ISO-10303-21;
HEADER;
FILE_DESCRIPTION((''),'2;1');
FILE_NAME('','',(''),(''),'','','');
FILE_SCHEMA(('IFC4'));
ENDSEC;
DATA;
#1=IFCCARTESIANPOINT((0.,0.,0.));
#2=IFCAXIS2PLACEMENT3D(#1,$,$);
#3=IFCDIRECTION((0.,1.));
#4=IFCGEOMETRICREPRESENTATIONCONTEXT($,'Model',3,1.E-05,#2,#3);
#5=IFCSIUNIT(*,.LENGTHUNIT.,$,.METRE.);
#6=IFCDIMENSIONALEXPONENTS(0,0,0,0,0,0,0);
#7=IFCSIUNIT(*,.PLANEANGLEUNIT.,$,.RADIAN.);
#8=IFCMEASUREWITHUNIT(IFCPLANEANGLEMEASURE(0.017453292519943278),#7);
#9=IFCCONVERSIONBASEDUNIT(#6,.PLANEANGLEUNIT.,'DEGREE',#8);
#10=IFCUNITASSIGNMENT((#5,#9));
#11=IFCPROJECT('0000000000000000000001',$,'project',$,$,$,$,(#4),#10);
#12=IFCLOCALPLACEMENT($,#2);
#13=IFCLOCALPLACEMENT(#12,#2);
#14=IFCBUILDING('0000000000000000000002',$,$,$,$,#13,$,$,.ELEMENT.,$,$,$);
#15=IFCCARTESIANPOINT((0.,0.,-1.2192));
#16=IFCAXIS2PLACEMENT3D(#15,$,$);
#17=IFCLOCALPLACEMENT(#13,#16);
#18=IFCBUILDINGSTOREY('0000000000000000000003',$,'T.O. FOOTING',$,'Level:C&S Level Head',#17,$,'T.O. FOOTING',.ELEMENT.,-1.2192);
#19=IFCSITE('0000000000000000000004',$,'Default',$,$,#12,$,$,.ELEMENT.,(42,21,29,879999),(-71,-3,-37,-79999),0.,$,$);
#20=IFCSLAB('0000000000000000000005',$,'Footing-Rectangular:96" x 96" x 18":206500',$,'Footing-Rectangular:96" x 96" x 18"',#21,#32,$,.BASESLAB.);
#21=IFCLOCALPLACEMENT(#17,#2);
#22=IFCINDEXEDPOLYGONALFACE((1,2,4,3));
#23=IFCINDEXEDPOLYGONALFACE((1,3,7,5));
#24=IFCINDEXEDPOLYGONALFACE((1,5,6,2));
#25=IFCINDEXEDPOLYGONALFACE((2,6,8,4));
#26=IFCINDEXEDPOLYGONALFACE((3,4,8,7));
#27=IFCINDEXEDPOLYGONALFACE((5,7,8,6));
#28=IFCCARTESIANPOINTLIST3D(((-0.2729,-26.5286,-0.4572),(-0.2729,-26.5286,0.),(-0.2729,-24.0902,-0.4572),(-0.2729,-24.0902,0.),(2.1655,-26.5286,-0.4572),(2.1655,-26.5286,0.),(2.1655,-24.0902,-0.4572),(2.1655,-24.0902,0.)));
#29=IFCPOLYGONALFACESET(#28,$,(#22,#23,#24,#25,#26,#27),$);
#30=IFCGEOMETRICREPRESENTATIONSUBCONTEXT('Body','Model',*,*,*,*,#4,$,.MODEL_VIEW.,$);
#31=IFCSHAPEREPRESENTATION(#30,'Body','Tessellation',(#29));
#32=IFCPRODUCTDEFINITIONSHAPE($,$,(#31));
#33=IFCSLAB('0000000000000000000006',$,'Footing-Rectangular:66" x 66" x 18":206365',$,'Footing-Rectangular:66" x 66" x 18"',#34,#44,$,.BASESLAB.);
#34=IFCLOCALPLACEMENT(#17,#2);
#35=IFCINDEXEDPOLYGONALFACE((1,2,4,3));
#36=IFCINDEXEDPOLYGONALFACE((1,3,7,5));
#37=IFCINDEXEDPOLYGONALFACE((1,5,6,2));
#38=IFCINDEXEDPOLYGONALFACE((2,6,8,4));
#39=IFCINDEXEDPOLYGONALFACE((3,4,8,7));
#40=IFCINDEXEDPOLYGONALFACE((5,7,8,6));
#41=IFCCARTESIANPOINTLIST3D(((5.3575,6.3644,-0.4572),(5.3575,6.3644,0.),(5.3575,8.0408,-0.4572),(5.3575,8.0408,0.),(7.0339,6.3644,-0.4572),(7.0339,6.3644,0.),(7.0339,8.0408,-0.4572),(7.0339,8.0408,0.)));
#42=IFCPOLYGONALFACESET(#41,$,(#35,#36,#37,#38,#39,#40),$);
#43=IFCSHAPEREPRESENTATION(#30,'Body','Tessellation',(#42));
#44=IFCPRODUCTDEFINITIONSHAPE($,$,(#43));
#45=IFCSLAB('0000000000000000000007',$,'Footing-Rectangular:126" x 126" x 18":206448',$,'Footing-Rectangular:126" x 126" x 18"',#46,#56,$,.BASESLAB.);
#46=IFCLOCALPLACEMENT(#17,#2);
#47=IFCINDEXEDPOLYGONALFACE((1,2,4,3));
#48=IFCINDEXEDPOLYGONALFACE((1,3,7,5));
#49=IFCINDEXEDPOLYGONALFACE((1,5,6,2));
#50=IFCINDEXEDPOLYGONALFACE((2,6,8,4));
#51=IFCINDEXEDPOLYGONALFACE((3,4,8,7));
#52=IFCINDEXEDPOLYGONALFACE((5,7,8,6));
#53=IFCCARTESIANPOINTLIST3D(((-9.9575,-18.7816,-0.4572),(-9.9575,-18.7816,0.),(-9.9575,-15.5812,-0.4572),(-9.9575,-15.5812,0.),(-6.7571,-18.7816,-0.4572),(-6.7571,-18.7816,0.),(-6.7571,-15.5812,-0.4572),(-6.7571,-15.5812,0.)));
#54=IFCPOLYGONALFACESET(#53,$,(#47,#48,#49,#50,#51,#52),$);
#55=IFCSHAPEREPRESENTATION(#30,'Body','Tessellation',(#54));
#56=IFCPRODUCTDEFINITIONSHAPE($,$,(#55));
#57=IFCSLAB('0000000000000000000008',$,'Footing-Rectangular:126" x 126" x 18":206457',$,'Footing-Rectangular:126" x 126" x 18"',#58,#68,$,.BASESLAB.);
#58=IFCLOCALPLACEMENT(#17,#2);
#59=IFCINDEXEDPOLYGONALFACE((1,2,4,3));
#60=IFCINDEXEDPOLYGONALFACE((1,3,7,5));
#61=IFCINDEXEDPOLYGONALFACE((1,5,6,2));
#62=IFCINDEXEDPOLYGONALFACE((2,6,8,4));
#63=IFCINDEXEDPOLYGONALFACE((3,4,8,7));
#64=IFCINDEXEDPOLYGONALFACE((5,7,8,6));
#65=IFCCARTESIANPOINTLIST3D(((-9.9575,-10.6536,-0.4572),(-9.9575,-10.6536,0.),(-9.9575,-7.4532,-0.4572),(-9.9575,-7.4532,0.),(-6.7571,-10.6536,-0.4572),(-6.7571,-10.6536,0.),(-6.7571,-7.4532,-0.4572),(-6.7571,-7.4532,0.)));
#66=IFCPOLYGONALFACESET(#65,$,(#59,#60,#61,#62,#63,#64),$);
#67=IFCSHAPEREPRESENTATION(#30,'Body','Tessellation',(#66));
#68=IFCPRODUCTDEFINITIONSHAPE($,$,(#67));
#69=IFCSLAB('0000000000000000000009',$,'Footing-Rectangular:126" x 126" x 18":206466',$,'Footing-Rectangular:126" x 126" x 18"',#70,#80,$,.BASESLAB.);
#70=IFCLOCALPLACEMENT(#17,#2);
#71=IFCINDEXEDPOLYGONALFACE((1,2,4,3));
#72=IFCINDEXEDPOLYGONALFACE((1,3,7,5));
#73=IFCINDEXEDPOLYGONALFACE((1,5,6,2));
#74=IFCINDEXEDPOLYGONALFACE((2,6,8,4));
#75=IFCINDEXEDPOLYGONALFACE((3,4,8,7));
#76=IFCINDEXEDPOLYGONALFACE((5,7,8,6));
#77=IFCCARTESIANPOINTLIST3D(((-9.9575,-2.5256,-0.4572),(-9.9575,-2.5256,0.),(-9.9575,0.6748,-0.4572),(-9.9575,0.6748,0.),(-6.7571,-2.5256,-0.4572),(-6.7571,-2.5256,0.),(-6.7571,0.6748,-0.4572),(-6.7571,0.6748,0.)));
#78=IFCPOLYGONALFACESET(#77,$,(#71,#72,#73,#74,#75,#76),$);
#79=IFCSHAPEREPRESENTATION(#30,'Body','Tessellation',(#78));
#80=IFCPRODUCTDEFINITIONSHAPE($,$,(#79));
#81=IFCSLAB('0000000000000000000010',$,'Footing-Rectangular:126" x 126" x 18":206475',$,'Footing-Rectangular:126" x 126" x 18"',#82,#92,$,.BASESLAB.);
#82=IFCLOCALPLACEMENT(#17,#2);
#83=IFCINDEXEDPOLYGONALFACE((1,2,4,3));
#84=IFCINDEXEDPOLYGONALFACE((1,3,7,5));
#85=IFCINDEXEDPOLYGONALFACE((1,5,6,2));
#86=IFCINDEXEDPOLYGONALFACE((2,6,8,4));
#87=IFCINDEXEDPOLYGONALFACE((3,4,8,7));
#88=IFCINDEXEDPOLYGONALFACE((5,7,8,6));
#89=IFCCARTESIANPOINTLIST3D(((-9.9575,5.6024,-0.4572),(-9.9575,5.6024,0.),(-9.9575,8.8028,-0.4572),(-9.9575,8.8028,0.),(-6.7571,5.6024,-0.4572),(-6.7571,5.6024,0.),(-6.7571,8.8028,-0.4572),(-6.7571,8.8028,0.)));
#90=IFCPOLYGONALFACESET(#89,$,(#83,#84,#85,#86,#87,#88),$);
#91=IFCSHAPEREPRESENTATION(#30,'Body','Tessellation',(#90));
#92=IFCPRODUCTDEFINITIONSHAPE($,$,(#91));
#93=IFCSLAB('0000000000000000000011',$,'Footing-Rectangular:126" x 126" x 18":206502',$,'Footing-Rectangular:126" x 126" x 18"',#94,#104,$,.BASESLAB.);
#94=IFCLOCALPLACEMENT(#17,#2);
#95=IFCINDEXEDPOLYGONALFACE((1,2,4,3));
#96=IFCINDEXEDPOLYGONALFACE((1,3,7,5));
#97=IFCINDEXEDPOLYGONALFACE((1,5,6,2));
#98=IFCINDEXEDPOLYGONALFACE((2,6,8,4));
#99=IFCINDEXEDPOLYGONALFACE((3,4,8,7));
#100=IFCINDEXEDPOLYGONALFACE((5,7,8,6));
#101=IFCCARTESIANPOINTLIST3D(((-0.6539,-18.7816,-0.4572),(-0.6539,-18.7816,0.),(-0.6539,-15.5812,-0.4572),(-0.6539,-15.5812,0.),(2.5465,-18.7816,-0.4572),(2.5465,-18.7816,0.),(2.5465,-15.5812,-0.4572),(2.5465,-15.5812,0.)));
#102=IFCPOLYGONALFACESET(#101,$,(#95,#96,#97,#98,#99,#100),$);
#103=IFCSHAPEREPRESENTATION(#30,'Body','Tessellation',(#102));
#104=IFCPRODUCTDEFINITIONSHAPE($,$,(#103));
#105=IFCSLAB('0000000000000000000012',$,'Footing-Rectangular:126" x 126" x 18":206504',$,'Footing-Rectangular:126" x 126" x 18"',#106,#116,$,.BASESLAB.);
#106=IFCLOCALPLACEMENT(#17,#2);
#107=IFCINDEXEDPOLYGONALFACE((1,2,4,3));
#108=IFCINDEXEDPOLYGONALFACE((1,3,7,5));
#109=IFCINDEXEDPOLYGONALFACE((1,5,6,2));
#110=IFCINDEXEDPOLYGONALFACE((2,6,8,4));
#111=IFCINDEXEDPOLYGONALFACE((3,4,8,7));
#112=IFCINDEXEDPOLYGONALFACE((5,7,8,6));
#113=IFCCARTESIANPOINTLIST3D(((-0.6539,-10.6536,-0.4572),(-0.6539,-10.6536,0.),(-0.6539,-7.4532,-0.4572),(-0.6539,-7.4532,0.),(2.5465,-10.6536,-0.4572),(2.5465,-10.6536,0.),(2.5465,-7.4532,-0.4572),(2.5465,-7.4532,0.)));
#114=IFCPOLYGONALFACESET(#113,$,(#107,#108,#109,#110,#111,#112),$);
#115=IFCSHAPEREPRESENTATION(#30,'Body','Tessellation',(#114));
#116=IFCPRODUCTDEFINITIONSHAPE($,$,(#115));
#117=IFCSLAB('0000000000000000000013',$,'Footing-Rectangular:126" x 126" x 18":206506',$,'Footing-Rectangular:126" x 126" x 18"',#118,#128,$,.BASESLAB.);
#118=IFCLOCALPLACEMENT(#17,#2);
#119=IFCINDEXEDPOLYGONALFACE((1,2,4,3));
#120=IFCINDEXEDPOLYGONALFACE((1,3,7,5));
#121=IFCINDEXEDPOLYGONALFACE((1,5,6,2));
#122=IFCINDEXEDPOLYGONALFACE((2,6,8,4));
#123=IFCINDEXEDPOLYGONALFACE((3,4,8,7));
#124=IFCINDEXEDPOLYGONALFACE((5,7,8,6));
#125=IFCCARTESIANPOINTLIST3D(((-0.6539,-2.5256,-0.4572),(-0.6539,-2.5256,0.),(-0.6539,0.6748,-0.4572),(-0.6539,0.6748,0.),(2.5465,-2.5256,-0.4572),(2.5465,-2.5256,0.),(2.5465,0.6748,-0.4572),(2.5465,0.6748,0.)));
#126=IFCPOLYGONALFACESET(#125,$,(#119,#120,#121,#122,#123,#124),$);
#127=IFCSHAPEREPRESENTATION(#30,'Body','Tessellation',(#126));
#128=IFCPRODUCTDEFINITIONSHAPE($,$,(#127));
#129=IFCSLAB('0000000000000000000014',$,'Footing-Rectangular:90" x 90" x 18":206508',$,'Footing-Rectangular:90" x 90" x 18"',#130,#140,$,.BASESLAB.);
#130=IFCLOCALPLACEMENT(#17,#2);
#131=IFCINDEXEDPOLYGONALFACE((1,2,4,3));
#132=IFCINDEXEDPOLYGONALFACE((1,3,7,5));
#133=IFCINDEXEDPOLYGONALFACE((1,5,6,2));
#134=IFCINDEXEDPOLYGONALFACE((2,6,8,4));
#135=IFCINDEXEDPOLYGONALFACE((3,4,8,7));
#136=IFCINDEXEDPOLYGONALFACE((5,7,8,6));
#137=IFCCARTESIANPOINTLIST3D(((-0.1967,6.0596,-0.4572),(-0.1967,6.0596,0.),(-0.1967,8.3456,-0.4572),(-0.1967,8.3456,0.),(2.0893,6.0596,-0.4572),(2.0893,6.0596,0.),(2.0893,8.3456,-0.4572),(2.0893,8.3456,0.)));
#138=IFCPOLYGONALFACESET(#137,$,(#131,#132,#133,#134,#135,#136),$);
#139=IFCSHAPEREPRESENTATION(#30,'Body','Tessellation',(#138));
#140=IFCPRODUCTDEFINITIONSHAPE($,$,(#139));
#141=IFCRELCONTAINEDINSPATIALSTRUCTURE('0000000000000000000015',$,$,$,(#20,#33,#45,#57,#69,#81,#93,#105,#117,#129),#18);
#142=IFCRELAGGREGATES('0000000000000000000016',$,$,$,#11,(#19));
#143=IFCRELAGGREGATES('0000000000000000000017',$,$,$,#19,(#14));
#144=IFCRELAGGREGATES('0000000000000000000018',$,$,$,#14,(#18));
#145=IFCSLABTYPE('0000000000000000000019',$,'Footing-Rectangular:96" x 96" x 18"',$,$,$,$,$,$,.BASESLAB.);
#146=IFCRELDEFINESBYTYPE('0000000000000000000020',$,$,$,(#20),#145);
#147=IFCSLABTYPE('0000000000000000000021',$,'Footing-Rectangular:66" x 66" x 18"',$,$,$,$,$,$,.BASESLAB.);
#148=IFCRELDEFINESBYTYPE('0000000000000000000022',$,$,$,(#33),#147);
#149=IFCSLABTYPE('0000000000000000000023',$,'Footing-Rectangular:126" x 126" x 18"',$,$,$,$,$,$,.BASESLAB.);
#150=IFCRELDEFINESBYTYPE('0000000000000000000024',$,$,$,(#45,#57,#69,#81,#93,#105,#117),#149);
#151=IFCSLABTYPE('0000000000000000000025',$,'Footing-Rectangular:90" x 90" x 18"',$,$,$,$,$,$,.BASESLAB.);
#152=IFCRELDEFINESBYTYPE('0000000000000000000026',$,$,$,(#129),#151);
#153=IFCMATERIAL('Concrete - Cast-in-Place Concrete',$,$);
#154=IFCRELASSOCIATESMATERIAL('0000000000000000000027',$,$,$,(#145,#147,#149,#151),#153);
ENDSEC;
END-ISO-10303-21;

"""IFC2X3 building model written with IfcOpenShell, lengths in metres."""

from ifc_helpers import new_model, entity, si_unit, converted_unit, direction, frame, frame_2d, origin, origin_2d_with_axis, place, context, subcontext, project, spatial, rectangle, extrude, material, type_object, element, save


model = new_model("IFC2X3")

# Units and contexts
model_context = context("Model", 3, precision=1e-05, world=origin(), true_north=direction((0.0, 1.0)))
body_context = subcontext(model_context, "Body", "Model", "MODEL_VIEW")
ifc_project = project(units=[si_unit("LENGTHUNIT", "METRE"), converted_unit("PLANEANGLEUNIT", "DEGREE", entity("IfcPlaneAngleMeasure", 0.017453292519943278), si_unit("PLANEANGLEUNIT", "RADIAN"), dimensions=[0, 0, 0, 0, 0, 0, 0])], contexts=[model_context])

# Site, building, storey
site_placement = place(None, origin())
site = spatial("IfcSite", under=ifc_project, at=site_placement, Name="Default", CompositionType="ELEMENT", RefLatitude=(42, 21, 29, 879999), RefLongitude=(-71, -3, -37, -79999), RefElevation=0.0)
building_placement = place(site_placement, origin())
building = spatial("IfcBuilding", under=site, at=building_placement, CompositionType="ELEMENT")
storey_placement = place(building_placement, frame((0.0, 0.0, -1.2192)))
storey = spatial("IfcBuildingStorey", under=building, at=storey_placement, Name="T.O. FOOTING", ObjectType="Level:C&S Level Head", LongName="T.O. FOOTING", CompositionType="ELEMENT", Elevation=-1.2192)

# Shared definitions
ifc_material = material(Name="Concrete - Cast-in-Place Concrete")

# Slabs
slab_type_1 = type_object("IfcSlabType", Name="Footing-Rectangular:96\" x 96\" x 18\"", PredefinedType="BASESLAB", material=ifc_material)
slab_1_placement = place(storey_placement, origin())
element("IfcSlab", 1, at=slab_1_placement, inside=storey, type_object=slab_type_1, Name="Footing-Rectangular:96\" x 96\" x 18\":206500", ObjectType="Footing-Rectangular:96\" x 96\" x 18\"", PredefinedType="BASESLAB", context=body_context, shape_type="SweptSolid", body=[
    extrude(rectangle(XDim=2.4384, YDim=2.4384, at=origin_2d_with_axis()), frame((0.9463, -25.3094, -0.4572), z_axis=(0.0, 0.0, 1.0), x_axis=(0.0, -1.0, 0.0)), (0.0, 0.0, 1.0), 0.4572),
])
slab_type_2 = type_object("IfcSlabType", Name="Footing-Rectangular:66\" x 66\" x 18\"", PredefinedType="BASESLAB", material=ifc_material)
slab_2_placement = place(storey_placement, origin())
element("IfcSlab", 2, at=slab_2_placement, inside=storey, type_object=slab_type_2, Name="Footing-Rectangular:66\" x 66\" x 18\":206365", ObjectType="Footing-Rectangular:66\" x 66\" x 18\"", PredefinedType="BASESLAB", context=body_context, shape_type="SweptSolid", body=[
    extrude(rectangle(XDim=1.6764, YDim=1.6764, at=origin_2d_with_axis()), frame((6.1957, 7.2026, -0.4572), z_axis=(0.0, 0.0, 1.0), x_axis=(0.0, -1.0, 0.0)), (0.0, 0.0, 1.0), 0.4572),
])
slab_type_3 = type_object("IfcSlabType", Name="Footing-Rectangular:126\" x 126\" x 18\"", PredefinedType="BASESLAB", material=ifc_material)
slab_3_placement = place(storey_placement, origin())
element("IfcSlab", 3, at=slab_3_placement, inside=storey, type_object=slab_type_3, Name="Footing-Rectangular:126\" x 126\" x 18\":206448", ObjectType="Footing-Rectangular:126\" x 126\" x 18\"", PredefinedType="BASESLAB", context=body_context, shape_type="SweptSolid", body=[
    extrude(rectangle(XDim=3.2004, YDim=3.2004, at=origin_2d_with_axis()), frame((-8.3573, -17.1814, -0.4572), z_axis=(0.0, 0.0, 1.0), x_axis=(-1.0, 0.0, 0.0)), (0.0, 0.0, 1.0), 0.4572),
])
slab_4_placement = place(storey_placement, origin())
element("IfcSlab", 4, at=slab_4_placement, inside=storey, type_object=slab_type_3, Name="Footing-Rectangular:126\" x 126\" x 18\":206457", ObjectType="Footing-Rectangular:126\" x 126\" x 18\"", PredefinedType="BASESLAB", context=body_context, shape_type="SweptSolid", body=[
    extrude(rectangle(XDim=3.2004, YDim=3.2004, at=origin_2d_with_axis()), frame((-8.3573, -9.0534, -0.4572), z_axis=(0.0, 0.0, 1.0), x_axis=(-1.0, 0.0, 0.0)), (0.0, 0.0, 1.0), 0.4572),
])
slab_5_placement = place(storey_placement, origin())
element("IfcSlab", 5, at=slab_5_placement, inside=storey, type_object=slab_type_3, Name="Footing-Rectangular:126\" x 126\" x 18\":206466", ObjectType="Footing-Rectangular:126\" x 126\" x 18\"", PredefinedType="BASESLAB", context=body_context, shape_type="SweptSolid", body=[
    extrude(rectangle(XDim=3.2004, YDim=3.2004, at=frame_2d((0.0, 0.0), x_axis=(1.0, 0.0))), frame((-8.3573, -0.9254, -0.4572), z_axis=(0.0, 0.0, 1.0), x_axis=(-1.0, 0.0, 0.0)), (0.0, 0.0, 1.0), 0.4572),
])
slab_6_placement = place(storey_placement, origin())
element("IfcSlab", 6, at=slab_6_placement, inside=storey, type_object=slab_type_3, Name="Footing-Rectangular:126\" x 126\" x 18\":206475", ObjectType="Footing-Rectangular:126\" x 126\" x 18\"", PredefinedType="BASESLAB", context=body_context, shape_type="SweptSolid", body=[
    extrude(rectangle(XDim=3.2004, YDim=3.2004, at=origin_2d_with_axis()), frame((-8.3573, 7.2026, -0.4572), z_axis=(0.0, 0.0, 1.0), x_axis=(-1.0, 0.0, 0.0)), (0.0, 0.0, 1.0), 0.4572),
])
slab_7_placement = place(storey_placement, origin())
element("IfcSlab", 7, at=slab_7_placement, inside=storey, type_object=slab_type_3, Name="Footing-Rectangular:126\" x 126\" x 18\":206502", ObjectType="Footing-Rectangular:126\" x 126\" x 18\"", PredefinedType="BASESLAB", context=body_context, shape_type="SweptSolid", body=[
    extrude(rectangle(XDim=3.2004, YDim=3.2004, at=origin_2d_with_axis()), frame((0.9463, -17.1814, -0.4572), z_axis=(0.0, 0.0, 1.0), x_axis=(0.0, -1.0, 0.0)), (0.0, 0.0, 1.0), 0.4572),
])
slab_8_placement = place(storey_placement, origin())
element("IfcSlab", 8, at=slab_8_placement, inside=storey, type_object=slab_type_3, Name="Footing-Rectangular:126\" x 126\" x 18\":206504", ObjectType="Footing-Rectangular:126\" x 126\" x 18\"", PredefinedType="BASESLAB", context=body_context, shape_type="SweptSolid", body=[
    extrude(rectangle(XDim=3.2004, YDim=3.2004, at=origin_2d_with_axis()), frame((0.9463, -9.0534, -0.4572), z_axis=(0.0, 0.0, 1.0), x_axis=(0.0, -1.0, 0.0)), (0.0, 0.0, 1.0), 0.4572),
])
slab_9_placement = place(storey_placement, origin())
element("IfcSlab", 9, at=slab_9_placement, inside=storey, type_object=slab_type_3, Name="Footing-Rectangular:126\" x 126\" x 18\":206506", ObjectType="Footing-Rectangular:126\" x 126\" x 18\"", PredefinedType="BASESLAB", context=body_context, shape_type="SweptSolid", body=[
    extrude(rectangle(XDim=3.2004, YDim=3.2004, at=frame_2d((0.0, 0.0), x_axis=(1.0, 0.0))), frame((0.9463, -0.9254, -0.4572), z_axis=(0.0, 0.0, 1.0), x_axis=(0.0, -1.0, 0.0)), (0.0, 0.0, 1.0), 0.4572),
])
slab_type_4 = type_object("IfcSlabType", Name="Footing-Rectangular:90\" x 90\" x 18\"", PredefinedType="BASESLAB", material=ifc_material)
slab_10_placement = place(storey_placement, origin())
element("IfcSlab", 10, at=slab_10_placement, inside=storey, type_object=slab_type_4, Name="Footing-Rectangular:90\" x 90\" x 18\":206508", ObjectType="Footing-Rectangular:90\" x 90\" x 18\"", PredefinedType="BASESLAB", context=body_context, shape_type="SweptSolid", body=[
    extrude(rectangle(XDim=2.286, YDim=2.286, at=origin_2d_with_axis()), frame((0.9463, 7.2026, -0.4572), z_axis=(0.0, 0.0, 1.0), x_axis=(0.0, -1.0, 0.0)), (0.0, 0.0, 1.0), 0.4572),
])

save(model, "model.ifc")
